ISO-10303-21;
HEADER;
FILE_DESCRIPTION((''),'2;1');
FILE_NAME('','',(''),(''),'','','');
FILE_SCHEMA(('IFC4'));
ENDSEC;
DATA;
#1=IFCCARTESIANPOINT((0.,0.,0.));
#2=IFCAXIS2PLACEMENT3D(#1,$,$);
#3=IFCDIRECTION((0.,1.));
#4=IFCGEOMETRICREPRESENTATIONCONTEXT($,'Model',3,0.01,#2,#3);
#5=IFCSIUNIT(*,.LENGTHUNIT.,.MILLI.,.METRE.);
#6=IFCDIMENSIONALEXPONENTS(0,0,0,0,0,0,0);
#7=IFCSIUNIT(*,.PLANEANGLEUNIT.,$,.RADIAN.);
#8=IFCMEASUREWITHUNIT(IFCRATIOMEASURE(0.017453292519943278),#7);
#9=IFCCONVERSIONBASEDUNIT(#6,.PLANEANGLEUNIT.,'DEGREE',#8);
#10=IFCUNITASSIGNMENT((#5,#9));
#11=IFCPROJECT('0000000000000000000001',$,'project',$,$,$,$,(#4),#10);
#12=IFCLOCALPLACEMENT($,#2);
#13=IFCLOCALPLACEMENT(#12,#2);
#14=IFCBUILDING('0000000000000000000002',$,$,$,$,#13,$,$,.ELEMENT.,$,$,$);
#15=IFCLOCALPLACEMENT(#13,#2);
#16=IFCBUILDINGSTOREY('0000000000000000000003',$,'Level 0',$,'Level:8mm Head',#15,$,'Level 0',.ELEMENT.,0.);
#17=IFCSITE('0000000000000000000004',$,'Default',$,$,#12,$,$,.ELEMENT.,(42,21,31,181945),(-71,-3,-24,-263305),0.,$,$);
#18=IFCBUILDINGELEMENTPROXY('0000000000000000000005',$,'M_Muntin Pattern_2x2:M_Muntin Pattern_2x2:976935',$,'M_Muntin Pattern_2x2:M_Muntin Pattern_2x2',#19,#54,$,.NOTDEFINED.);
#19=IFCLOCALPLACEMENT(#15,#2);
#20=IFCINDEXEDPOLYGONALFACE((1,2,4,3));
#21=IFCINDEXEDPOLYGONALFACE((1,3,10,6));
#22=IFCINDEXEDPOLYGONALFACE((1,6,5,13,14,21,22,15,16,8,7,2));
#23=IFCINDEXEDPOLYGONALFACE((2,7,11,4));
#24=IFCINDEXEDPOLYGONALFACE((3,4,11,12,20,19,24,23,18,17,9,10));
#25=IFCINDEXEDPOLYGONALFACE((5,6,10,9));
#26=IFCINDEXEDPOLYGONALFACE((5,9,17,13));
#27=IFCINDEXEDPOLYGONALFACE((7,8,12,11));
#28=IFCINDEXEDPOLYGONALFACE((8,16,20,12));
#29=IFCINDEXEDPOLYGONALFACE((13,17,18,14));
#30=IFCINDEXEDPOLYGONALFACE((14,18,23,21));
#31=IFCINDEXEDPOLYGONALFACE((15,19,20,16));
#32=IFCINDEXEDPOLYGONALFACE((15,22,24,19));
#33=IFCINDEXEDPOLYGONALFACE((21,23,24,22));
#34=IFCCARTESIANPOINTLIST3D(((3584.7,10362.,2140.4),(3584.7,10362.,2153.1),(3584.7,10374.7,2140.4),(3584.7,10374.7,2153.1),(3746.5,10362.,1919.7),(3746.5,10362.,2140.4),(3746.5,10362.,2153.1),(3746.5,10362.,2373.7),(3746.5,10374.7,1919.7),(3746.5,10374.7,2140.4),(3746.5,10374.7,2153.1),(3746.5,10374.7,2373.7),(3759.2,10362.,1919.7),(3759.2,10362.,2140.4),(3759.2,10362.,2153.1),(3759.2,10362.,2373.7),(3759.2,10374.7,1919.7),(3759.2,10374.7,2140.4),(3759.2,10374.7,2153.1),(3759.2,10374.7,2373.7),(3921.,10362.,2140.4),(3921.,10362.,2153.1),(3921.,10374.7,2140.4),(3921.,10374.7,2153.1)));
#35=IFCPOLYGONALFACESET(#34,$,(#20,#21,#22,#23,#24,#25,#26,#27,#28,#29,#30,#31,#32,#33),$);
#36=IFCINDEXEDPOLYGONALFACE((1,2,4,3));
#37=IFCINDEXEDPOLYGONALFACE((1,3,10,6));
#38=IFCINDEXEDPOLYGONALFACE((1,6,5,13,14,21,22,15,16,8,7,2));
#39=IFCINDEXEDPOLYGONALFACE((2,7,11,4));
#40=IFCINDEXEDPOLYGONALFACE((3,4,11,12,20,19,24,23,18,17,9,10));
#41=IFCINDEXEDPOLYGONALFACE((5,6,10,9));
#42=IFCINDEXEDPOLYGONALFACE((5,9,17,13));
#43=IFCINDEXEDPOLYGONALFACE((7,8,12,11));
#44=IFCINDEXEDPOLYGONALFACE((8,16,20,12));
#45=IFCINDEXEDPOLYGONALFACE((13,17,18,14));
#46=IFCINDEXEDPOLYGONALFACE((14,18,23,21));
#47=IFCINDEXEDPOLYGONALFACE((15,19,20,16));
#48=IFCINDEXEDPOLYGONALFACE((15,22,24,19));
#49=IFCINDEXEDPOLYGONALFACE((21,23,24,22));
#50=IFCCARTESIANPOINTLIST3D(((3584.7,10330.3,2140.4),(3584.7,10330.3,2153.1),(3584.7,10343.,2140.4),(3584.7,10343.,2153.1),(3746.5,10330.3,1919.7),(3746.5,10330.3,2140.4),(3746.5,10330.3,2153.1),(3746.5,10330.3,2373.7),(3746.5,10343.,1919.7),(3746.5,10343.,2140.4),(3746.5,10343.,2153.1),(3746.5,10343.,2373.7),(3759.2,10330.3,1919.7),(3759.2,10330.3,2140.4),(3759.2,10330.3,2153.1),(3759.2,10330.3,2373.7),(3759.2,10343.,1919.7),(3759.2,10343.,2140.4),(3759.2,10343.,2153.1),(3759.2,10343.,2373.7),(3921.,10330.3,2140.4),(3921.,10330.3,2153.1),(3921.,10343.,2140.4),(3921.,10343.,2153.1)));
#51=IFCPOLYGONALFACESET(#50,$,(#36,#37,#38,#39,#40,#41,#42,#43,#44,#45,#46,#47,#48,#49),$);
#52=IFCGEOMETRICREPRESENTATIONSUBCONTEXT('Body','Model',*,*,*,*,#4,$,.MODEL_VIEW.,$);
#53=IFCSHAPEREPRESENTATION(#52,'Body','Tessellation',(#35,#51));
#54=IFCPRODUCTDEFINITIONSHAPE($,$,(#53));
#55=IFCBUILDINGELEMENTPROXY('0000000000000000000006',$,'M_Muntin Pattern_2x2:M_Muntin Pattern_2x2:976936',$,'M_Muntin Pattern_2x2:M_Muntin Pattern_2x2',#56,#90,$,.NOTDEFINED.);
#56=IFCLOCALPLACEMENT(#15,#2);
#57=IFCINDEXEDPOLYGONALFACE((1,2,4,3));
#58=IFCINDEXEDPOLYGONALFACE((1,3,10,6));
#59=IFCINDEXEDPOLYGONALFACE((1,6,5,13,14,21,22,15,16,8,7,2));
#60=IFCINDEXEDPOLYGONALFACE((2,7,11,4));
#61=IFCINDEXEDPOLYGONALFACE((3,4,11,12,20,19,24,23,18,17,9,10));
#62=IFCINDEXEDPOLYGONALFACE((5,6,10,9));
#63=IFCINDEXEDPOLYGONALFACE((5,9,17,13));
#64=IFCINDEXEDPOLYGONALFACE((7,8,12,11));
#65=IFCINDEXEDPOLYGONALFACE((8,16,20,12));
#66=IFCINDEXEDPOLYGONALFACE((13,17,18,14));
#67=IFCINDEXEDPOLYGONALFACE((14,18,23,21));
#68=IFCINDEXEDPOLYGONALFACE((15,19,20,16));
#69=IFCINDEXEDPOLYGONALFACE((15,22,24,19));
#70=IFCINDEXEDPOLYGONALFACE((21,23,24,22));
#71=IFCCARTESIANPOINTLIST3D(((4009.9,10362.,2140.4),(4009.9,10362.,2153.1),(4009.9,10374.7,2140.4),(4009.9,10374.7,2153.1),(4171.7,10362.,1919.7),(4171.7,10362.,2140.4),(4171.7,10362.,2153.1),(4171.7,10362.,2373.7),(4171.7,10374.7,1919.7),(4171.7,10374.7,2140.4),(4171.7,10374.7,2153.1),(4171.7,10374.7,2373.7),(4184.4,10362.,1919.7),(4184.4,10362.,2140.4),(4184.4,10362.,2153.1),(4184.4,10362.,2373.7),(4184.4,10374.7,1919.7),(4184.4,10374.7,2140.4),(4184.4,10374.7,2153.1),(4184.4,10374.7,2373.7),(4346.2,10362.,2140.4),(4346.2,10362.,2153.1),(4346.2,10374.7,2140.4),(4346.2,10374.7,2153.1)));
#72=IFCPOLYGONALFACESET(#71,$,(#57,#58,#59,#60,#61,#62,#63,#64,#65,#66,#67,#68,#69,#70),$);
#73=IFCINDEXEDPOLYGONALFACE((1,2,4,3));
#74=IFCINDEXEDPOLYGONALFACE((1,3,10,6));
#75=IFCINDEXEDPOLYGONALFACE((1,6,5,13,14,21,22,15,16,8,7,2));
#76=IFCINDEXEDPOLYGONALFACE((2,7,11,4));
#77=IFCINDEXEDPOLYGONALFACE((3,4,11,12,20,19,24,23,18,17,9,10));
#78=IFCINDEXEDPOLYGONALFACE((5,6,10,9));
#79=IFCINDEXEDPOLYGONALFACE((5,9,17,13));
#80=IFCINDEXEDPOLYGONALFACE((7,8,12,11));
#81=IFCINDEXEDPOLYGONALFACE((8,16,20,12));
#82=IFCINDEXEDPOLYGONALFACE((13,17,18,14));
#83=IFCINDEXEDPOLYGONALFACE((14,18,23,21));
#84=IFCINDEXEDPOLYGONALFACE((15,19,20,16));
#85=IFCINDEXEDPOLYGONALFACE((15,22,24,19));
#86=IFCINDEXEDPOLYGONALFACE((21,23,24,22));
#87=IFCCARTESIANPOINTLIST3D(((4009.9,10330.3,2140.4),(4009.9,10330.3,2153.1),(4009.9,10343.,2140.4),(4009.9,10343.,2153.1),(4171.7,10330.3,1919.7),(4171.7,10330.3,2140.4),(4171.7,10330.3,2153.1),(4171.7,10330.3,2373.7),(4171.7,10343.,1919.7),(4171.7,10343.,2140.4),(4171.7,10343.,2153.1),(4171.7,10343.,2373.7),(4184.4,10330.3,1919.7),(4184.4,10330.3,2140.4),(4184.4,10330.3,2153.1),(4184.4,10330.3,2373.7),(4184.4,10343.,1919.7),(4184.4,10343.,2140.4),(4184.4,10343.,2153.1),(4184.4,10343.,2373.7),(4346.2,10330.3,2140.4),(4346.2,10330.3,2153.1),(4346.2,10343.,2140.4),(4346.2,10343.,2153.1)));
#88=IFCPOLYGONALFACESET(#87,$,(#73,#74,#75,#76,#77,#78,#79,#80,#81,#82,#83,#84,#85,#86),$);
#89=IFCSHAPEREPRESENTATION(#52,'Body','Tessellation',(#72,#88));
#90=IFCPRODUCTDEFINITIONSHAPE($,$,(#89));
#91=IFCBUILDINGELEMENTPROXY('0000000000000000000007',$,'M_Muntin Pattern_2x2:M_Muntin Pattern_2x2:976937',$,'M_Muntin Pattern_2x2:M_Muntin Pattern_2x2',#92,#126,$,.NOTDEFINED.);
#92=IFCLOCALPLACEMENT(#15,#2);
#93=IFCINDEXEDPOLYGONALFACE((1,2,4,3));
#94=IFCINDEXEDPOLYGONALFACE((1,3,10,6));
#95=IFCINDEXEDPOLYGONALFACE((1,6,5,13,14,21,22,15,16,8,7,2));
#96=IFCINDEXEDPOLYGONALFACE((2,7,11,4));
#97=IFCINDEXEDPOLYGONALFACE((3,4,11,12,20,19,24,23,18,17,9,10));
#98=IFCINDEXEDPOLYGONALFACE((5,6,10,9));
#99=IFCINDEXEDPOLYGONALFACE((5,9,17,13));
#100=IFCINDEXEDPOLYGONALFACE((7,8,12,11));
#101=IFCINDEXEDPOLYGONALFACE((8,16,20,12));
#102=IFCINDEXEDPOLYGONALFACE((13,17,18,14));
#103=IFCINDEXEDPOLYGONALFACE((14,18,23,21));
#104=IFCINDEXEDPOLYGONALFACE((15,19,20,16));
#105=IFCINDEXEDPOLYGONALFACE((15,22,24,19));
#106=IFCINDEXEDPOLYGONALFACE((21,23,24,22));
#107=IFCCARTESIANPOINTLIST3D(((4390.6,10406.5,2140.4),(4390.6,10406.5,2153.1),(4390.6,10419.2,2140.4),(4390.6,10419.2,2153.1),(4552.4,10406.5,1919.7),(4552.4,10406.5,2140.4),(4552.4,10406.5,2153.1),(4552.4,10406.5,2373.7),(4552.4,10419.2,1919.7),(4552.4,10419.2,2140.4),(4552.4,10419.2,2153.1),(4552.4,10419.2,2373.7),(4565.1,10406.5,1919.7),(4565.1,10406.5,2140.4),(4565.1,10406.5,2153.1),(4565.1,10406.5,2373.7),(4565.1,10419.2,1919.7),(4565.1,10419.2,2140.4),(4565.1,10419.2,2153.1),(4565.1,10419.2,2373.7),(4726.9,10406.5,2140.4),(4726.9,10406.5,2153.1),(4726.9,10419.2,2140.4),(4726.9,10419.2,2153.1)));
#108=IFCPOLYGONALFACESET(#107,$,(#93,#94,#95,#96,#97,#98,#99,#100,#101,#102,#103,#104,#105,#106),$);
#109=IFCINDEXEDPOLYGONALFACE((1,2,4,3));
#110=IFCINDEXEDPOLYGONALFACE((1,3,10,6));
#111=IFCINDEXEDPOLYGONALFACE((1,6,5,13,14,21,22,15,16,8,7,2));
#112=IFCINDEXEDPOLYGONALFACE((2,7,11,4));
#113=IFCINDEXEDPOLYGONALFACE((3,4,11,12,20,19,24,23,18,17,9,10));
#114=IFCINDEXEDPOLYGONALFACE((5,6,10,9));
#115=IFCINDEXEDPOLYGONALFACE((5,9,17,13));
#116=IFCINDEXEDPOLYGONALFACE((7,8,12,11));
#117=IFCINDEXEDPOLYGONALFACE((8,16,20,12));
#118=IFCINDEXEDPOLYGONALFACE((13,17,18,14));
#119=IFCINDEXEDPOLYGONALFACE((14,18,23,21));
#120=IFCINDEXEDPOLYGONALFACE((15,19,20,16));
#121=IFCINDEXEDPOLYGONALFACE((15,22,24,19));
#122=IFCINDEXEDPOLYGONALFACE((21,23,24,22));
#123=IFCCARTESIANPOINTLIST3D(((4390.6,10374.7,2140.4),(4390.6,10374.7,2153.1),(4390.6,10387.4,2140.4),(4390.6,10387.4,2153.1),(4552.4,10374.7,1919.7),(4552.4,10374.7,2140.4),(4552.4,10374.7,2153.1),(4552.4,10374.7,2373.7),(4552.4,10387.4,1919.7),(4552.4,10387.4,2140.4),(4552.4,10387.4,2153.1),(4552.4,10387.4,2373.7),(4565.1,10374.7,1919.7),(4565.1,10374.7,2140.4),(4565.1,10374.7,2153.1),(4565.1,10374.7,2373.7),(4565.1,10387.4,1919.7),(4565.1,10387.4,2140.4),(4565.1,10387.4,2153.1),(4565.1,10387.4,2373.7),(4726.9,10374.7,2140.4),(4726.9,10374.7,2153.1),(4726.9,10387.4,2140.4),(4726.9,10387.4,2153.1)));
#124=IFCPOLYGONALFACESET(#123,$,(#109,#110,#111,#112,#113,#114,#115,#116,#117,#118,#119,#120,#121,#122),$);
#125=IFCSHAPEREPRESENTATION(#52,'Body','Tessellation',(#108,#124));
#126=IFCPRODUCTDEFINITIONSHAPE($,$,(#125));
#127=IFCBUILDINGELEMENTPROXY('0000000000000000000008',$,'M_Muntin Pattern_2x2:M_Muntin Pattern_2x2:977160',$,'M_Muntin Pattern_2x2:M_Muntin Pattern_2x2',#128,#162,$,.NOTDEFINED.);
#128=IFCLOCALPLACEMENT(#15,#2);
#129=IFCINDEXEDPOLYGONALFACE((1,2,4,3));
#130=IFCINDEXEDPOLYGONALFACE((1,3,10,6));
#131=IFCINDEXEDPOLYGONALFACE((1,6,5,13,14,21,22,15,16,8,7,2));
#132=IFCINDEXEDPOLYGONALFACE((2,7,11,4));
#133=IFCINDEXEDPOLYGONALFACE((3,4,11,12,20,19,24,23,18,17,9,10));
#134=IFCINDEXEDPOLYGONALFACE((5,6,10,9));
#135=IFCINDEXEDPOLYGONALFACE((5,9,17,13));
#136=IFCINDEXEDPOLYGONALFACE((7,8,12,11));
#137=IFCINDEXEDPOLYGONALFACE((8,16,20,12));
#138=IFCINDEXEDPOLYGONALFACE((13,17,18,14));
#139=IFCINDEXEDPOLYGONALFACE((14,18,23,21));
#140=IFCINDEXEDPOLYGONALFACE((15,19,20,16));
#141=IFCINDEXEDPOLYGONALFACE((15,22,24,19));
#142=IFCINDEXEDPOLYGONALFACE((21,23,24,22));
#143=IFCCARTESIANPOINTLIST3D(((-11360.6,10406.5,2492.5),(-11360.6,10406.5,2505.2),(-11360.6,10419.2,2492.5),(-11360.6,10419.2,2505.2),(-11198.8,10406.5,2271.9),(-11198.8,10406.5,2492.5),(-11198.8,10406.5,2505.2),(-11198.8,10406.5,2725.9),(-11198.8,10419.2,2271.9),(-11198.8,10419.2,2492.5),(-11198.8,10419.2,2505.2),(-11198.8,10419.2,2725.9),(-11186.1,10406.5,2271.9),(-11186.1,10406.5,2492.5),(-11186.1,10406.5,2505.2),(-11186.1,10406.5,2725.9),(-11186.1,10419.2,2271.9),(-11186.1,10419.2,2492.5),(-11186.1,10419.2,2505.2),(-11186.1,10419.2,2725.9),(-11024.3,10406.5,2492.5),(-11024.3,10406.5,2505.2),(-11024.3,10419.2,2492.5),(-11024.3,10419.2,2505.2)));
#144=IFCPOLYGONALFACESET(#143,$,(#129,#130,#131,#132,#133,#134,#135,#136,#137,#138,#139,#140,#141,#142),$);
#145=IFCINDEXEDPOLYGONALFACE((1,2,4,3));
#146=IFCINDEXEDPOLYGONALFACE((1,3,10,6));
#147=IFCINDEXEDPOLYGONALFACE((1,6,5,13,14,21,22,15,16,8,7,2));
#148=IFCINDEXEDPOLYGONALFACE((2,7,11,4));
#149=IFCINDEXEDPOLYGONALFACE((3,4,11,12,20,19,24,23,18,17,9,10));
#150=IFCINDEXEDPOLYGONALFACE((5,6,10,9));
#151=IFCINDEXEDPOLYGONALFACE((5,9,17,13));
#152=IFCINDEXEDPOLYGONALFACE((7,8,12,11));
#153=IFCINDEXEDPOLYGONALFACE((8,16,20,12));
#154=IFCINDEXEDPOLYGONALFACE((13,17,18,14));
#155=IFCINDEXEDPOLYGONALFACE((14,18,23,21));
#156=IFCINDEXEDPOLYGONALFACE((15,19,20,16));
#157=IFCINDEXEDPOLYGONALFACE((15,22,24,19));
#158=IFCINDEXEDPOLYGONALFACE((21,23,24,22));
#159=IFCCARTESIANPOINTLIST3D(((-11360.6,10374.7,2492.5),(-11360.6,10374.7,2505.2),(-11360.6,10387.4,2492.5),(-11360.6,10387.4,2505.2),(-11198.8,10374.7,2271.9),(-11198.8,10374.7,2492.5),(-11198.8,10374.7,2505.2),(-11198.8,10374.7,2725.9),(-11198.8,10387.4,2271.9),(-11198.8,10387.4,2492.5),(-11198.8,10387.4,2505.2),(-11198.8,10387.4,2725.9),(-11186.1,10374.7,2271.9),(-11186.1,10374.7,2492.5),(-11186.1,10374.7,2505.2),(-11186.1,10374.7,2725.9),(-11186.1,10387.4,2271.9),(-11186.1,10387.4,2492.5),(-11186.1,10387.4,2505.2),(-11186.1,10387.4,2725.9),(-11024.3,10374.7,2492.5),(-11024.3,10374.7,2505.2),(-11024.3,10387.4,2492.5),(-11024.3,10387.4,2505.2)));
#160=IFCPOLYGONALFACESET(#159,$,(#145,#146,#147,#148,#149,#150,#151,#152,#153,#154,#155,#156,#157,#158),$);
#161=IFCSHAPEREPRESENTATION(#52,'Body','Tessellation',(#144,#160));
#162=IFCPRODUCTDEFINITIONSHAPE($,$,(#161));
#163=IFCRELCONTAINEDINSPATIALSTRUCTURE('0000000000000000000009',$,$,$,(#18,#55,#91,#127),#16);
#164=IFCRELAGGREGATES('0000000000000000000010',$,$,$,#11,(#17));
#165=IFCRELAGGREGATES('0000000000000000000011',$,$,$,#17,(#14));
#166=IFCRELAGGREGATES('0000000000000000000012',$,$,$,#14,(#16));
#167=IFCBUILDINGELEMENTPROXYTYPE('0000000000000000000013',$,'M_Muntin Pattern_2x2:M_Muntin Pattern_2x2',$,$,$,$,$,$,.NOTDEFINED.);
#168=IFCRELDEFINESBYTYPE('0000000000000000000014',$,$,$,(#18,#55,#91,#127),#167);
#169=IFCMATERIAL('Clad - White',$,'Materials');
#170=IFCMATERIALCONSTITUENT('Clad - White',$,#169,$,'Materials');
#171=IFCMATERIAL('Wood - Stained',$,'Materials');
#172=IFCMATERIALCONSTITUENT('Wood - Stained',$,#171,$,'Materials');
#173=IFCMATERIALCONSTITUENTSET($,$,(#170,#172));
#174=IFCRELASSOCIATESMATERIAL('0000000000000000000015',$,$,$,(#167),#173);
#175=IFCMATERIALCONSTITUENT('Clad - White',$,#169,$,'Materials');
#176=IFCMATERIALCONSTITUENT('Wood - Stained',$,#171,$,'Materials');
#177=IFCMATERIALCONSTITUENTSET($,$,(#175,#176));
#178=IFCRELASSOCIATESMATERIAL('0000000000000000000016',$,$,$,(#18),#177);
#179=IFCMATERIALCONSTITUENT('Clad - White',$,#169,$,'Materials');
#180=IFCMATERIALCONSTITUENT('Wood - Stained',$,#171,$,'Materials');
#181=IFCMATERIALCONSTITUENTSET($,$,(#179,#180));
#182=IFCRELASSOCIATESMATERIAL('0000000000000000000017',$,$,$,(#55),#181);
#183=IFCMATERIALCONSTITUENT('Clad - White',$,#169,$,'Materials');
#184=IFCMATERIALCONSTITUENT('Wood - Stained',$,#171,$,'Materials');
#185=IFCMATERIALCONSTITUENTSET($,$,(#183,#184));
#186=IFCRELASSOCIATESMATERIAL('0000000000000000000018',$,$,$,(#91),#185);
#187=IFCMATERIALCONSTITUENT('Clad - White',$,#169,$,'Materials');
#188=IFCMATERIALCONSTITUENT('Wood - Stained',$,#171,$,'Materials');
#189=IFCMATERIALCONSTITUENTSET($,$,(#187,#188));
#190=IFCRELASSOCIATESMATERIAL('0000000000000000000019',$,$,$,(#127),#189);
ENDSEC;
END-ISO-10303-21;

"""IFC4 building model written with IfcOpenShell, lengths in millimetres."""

from ifc_helpers import new_model, entity, si_unit, converted_unit, direction, frame, origin, place, context, subcontext, project, spatial, indexed_curve, outline, extrude, source, transform, mapped, material, constituent, constituent_set, type_object, type_shapes, element, save


model = new_model("IFC4")

# Units and contexts
model_context = context("Model", 3, precision=0.01, world=origin(), true_north=direction((0.0, 1.0)))
body_context = subcontext(model_context, "Body", "Model", "MODEL_VIEW")
ifc_project = project(units=[si_unit("LENGTHUNIT", "METRE", prefix="MILLI"), converted_unit("PLANEANGLEUNIT", "DEGREE", entity("IfcRatioMeasure", 0.017453292519943278), si_unit("PLANEANGLEUNIT", "RADIAN"), dimensions=[0, 0, 0, 0, 0, 0, 0])], contexts=[model_context])

# Site, building, storey
site_placement = place(None, origin())
site = spatial("IfcSite", under=ifc_project, at=site_placement, Name="Default", CompositionType="ELEMENT", RefLatitude=(42, 21, 31, 181945), RefLongitude=(-71, -3, -24, -263305), RefElevation=0.0)
building_placement = place(site_placement, origin())
building = spatial("IfcBuilding", under=site, at=building_placement, CompositionType="ELEMENT")
storey_placement = place(building_placement, origin())
storey = spatial("IfcBuildingStorey", under=building, at=storey_placement, Name="Level 0", ObjectType="Level:8mm Head", LongName="Level 0", CompositionType="ELEMENT", Elevation=0.0)

# Building element proxies
ifc_material_1 = material(Name="Clad - White", Category="Materials")
ifc_material_2 = material(Name="Wood - Stained", Category="Materials")
ifc_constituent_1 = constituent(ifc_material_1, Name="Clad - White", Category="Materials")
ifc_constituent_2 = constituent(ifc_material_2, Name="Wood - Stained", Category="Materials")
ifc_constituent_set_1 = constituent_set(constituents=[ifc_constituent_1, ifc_constituent_2])
building_element_proxy_type_1 = type_object("IfcBuildingElementProxyType", Name="M_Muntin Pattern_2x2:M_Muntin Pattern_2x2", PredefinedType="NOTDEFINED", material=ifc_constituent_set_1)
shared_shape_1 = source(origin(), body_context, "Body", "SweptSolid", [
    extrude(outline(indexed_curve([(6.4, -6.4), (227.0, -6.4), (227.0, 6.3), (6.4, 6.3), (6.4, 168.2), (-6.3, 168.2), (-6.3, 6.3), (-227.0, 6.3), (-227.0, -6.4), (-6.3, -6.4), (-6.3, -168.1), (6.4, -168.1), (6.4, -6.4)], self_intersect=False)), frame((0.0, 9.5, 227.0), z_axis=(0.0, 1.0, 0.0), x_axis=(0.0, 0.0, 1.0)), (0.0, 0.0, 1.0), 12.7),
    extrude(outline(indexed_curve([(6.4, -6.4), (227.0, -6.4), (227.0, 6.3), (6.4, 6.3), (6.4, 168.2), (-6.3, 168.2), (-6.3, 6.3), (-227.0, 6.3), (-227.0, -6.4), (-6.3, -6.4), (-6.3, -168.1), (6.4, -168.1), (6.4, -6.4)], self_intersect=False)), frame((0.0, -22.2, 227.0), z_axis=(0.0, 1.0, 0.0), x_axis=(0.0, 0.0, 1.0)), (0.0, 0.0, 1.0), 12.7),
])
type_shapes(building_element_proxy_type_1, [shared_shape_1])
ifc_constituent_3 = constituent(ifc_material_1, Name="Clad - White", Category="Materials")
ifc_constituent_4 = constituent(ifc_material_2, Name="Wood - Stained", Category="Materials")
ifc_constituent_set_2 = constituent_set(constituents=[ifc_constituent_3, ifc_constituent_4])
proxy_1_placement = place(storey_placement, frame((3752.8, 10352.5, 1919.7)))
element("IfcBuildingElementProxy", 1, at=proxy_1_placement, inside=storey, type_object=building_element_proxy_type_1, material=ifc_constituent_set_2, Name="M_Muntin Pattern_2x2:M_Muntin Pattern_2x2:976935", ObjectType="M_Muntin Pattern_2x2:M_Muntin Pattern_2x2", PredefinedType="NOTDEFINED", context=body_context, shape_type="MappedRepresentation", body=[
    mapped(shared_shape_1, transform((0.0, 0.0, 0.0), scale=1.0)),
])
ifc_constituent_5 = constituent(ifc_material_1, Name="Clad - White", Category="Materials")
ifc_constituent_6 = constituent(ifc_material_2, Name="Wood - Stained", Category="Materials")
ifc_constituent_set_3 = constituent_set(constituents=[ifc_constituent_5, ifc_constituent_6])
proxy_2_placement = place(storey_placement, frame((4178.0, 10352.5, 1919.7)))
element("IfcBuildingElementProxy", 2, at=proxy_2_placement, inside=storey, type_object=building_element_proxy_type_1, material=ifc_constituent_set_3, Name="M_Muntin Pattern_2x2:M_Muntin Pattern_2x2:976936", ObjectType="M_Muntin Pattern_2x2:M_Muntin Pattern_2x2", PredefinedType="NOTDEFINED", context=body_context, shape_type="MappedRepresentation", body=[
    mapped(shared_shape_1, transform((0.0, 0.0, 0.0), scale=1.0)),
])
ifc_constituent_7 = constituent(ifc_material_1, Name="Clad - White", Category="Materials")
ifc_constituent_8 = constituent(ifc_material_2, Name="Wood - Stained", Category="Materials")
ifc_constituent_set_4 = constituent_set(constituents=[ifc_constituent_7, ifc_constituent_8])
proxy_3_placement = place(storey_placement, frame((4558.8, 10396.9, 1919.7)))
element("IfcBuildingElementProxy", 3, at=proxy_3_placement, inside=storey, type_object=building_element_proxy_type_1, material=ifc_constituent_set_4, Name="M_Muntin Pattern_2x2:M_Muntin Pattern_2x2:976937", ObjectType="M_Muntin Pattern_2x2:M_Muntin Pattern_2x2", PredefinedType="NOTDEFINED", context=body_context, shape_type="MappedRepresentation", body=[
    mapped(shared_shape_1, transform((0.0, 0.0, 0.0), scale=1.0)),
])
ifc_constituent_9 = constituent(ifc_material_1, Name="Clad - White", Category="Materials")
ifc_constituent_10 = constituent(ifc_material_2, Name="Wood - Stained", Category="Materials")
ifc_constituent_set_5 = constituent_set(constituents=[ifc_constituent_9, ifc_constituent_10])
proxy_4_placement = place(storey_placement, frame((-11192.4, 10396.9, 2271.9)))
element("IfcBuildingElementProxy", 4, at=proxy_4_placement, inside=storey, type_object=building_element_proxy_type_1, material=ifc_constituent_set_5, Name="M_Muntin Pattern_2x2:M_Muntin Pattern_2x2:977160", ObjectType="M_Muntin Pattern_2x2:M_Muntin Pattern_2x2", PredefinedType="NOTDEFINED", context=body_context, shape_type="MappedRepresentation", body=[
    mapped(shared_shape_1, transform((0.0, 0.0, 0.0), scale=1.0)),
])

save(model, "model.ifc")
